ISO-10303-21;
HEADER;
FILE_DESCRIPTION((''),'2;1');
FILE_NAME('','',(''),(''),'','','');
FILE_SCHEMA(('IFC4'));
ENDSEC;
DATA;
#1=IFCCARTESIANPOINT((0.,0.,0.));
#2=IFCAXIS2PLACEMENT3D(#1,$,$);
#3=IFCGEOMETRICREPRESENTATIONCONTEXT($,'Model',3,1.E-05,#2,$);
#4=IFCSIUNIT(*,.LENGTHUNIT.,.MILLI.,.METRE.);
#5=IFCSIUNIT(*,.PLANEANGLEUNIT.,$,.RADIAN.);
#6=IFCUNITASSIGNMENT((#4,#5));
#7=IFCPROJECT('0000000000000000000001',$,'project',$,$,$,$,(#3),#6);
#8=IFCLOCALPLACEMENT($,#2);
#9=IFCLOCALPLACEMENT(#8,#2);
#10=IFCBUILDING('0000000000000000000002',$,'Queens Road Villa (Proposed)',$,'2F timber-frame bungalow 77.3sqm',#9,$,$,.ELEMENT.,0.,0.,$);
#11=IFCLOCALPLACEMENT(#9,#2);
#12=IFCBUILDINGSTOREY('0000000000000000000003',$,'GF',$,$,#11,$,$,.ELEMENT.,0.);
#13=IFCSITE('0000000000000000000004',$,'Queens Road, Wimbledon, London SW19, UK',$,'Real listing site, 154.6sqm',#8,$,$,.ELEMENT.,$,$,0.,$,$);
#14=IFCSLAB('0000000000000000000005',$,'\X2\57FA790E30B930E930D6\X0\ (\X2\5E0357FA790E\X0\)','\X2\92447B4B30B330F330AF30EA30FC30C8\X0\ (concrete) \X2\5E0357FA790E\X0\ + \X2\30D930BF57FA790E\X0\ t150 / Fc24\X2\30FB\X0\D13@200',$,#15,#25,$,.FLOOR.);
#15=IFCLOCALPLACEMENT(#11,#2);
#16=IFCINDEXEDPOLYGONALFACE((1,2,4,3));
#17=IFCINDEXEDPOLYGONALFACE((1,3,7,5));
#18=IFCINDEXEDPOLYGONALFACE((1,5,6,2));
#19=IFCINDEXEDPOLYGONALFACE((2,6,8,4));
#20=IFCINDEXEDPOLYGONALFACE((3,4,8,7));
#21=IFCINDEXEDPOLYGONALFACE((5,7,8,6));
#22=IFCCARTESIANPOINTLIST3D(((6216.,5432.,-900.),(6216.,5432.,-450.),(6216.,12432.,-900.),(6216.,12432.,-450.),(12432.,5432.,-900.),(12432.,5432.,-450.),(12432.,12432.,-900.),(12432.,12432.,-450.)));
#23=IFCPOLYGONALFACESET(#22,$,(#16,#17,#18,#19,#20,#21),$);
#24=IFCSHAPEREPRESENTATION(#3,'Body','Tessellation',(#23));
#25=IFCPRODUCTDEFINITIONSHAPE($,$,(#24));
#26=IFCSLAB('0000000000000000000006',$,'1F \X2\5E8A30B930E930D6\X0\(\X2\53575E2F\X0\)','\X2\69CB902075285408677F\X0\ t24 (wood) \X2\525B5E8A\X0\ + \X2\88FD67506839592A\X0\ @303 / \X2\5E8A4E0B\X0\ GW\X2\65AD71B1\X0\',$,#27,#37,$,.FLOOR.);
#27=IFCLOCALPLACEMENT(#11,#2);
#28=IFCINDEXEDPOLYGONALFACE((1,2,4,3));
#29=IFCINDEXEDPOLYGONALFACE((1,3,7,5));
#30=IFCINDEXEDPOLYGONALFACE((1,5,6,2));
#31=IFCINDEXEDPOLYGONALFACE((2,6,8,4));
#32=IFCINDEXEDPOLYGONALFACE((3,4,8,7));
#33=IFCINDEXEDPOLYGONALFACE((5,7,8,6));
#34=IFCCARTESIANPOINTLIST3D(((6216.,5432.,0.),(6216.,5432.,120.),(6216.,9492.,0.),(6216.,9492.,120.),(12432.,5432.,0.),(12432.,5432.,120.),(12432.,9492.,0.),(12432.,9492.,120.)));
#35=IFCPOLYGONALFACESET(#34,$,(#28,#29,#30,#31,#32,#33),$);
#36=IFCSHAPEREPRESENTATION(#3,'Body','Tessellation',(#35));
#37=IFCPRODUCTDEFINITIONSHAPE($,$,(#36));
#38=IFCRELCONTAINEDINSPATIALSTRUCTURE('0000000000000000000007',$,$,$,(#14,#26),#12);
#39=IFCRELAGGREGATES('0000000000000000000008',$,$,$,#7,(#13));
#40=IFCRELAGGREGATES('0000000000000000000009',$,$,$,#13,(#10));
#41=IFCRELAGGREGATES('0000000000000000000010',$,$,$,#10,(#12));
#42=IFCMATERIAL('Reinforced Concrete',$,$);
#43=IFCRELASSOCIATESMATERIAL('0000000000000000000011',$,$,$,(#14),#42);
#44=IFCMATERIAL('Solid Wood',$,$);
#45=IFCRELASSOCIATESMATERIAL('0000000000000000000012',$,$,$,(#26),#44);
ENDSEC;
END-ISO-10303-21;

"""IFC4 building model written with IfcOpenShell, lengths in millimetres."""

from ifc_helpers import new_model, si_unit, frame, frame_2d, origin, place, context, project, spatial, rectangle, extrude, material, element, save


model = new_model("IFC4")

# Units and contexts
model_context = context("Model", 3, precision=1e-05, world=origin())
ifc_project = project(units=[si_unit("LENGTHUNIT", "METRE", prefix="MILLI"), si_unit("PLANEANGLEUNIT", "RADIAN")], contexts=[model_context])

# Site, building, storey
site_placement = place(None, origin())
site = spatial("IfcSite", under=ifc_project, at=site_placement, Name="Queens Road, Wimbledon, London SW19, UK", ObjectType="Real listing site, 154.6sqm", CompositionType="ELEMENT", RefElevation=0.0)
building_placement = place(site_placement, origin())
building = spatial("IfcBuilding", under=site, at=building_placement, Name="Queens Road Villa (Proposed)", ObjectType="2F timber-frame bungalow 77.3sqm", CompositionType="ELEMENT", ElevationOfRefHeight=0.0, ElevationOfTerrain=0.0)
storey_placement = place(building_placement, origin())
storey = spatial("IfcBuildingStorey", under=building, at=storey_placement, Name="GF", CompositionType="ELEMENT", Elevation=0.0)

# Slabs
ifc_material_1 = material(Name="Reinforced Concrete")
slab_1_placement = place(storey_placement, frame((3108.0, 2716.0, -450.0)))
element("IfcSlab", 1, at=slab_1_placement, inside=storey, material=ifc_material_1, Name="基礎スラブ (布基礎)", Description="鉄筋コンクリート (concrete) 布基礎 + ベタ基礎 t150 / Fc24・D13@200", PredefinedType="FLOOR", context=model_context, shape_type="SweptSolid", body=[
    extrude(rectangle(XDim=6216.0, YDim=7000.0, at=frame_2d((3108.0, 3500.0))), frame((3108.0, 2716.0, -450.0)), (0.0, 0.0, 1.0), 450.0),
])
ifc_material_2 = material(Name="Solid Wood")
slab_2_placement = place(storey_placement, frame((3108.0, 2716.0, 0.0)))
element("IfcSlab", 2, at=slab_2_placement, inside=storey, material=ifc_material_2, Name="1F 床スラブ(南帯)", Description="構造用合板 t24 (wood) 剛床 + 製材根太 @303 / 床下 GW断熱", PredefinedType="FLOOR", context=model_context, shape_type="SweptSolid", body=[
    extrude(rectangle(XDim=6216.0, YDim=4060.0, at=frame_2d((3108.0, 2030.0))), frame((3108.0, 2716.0, 0.0)), (0.0, 0.0, 1.0), 120.0),
])

save(model, "model.ifc")
